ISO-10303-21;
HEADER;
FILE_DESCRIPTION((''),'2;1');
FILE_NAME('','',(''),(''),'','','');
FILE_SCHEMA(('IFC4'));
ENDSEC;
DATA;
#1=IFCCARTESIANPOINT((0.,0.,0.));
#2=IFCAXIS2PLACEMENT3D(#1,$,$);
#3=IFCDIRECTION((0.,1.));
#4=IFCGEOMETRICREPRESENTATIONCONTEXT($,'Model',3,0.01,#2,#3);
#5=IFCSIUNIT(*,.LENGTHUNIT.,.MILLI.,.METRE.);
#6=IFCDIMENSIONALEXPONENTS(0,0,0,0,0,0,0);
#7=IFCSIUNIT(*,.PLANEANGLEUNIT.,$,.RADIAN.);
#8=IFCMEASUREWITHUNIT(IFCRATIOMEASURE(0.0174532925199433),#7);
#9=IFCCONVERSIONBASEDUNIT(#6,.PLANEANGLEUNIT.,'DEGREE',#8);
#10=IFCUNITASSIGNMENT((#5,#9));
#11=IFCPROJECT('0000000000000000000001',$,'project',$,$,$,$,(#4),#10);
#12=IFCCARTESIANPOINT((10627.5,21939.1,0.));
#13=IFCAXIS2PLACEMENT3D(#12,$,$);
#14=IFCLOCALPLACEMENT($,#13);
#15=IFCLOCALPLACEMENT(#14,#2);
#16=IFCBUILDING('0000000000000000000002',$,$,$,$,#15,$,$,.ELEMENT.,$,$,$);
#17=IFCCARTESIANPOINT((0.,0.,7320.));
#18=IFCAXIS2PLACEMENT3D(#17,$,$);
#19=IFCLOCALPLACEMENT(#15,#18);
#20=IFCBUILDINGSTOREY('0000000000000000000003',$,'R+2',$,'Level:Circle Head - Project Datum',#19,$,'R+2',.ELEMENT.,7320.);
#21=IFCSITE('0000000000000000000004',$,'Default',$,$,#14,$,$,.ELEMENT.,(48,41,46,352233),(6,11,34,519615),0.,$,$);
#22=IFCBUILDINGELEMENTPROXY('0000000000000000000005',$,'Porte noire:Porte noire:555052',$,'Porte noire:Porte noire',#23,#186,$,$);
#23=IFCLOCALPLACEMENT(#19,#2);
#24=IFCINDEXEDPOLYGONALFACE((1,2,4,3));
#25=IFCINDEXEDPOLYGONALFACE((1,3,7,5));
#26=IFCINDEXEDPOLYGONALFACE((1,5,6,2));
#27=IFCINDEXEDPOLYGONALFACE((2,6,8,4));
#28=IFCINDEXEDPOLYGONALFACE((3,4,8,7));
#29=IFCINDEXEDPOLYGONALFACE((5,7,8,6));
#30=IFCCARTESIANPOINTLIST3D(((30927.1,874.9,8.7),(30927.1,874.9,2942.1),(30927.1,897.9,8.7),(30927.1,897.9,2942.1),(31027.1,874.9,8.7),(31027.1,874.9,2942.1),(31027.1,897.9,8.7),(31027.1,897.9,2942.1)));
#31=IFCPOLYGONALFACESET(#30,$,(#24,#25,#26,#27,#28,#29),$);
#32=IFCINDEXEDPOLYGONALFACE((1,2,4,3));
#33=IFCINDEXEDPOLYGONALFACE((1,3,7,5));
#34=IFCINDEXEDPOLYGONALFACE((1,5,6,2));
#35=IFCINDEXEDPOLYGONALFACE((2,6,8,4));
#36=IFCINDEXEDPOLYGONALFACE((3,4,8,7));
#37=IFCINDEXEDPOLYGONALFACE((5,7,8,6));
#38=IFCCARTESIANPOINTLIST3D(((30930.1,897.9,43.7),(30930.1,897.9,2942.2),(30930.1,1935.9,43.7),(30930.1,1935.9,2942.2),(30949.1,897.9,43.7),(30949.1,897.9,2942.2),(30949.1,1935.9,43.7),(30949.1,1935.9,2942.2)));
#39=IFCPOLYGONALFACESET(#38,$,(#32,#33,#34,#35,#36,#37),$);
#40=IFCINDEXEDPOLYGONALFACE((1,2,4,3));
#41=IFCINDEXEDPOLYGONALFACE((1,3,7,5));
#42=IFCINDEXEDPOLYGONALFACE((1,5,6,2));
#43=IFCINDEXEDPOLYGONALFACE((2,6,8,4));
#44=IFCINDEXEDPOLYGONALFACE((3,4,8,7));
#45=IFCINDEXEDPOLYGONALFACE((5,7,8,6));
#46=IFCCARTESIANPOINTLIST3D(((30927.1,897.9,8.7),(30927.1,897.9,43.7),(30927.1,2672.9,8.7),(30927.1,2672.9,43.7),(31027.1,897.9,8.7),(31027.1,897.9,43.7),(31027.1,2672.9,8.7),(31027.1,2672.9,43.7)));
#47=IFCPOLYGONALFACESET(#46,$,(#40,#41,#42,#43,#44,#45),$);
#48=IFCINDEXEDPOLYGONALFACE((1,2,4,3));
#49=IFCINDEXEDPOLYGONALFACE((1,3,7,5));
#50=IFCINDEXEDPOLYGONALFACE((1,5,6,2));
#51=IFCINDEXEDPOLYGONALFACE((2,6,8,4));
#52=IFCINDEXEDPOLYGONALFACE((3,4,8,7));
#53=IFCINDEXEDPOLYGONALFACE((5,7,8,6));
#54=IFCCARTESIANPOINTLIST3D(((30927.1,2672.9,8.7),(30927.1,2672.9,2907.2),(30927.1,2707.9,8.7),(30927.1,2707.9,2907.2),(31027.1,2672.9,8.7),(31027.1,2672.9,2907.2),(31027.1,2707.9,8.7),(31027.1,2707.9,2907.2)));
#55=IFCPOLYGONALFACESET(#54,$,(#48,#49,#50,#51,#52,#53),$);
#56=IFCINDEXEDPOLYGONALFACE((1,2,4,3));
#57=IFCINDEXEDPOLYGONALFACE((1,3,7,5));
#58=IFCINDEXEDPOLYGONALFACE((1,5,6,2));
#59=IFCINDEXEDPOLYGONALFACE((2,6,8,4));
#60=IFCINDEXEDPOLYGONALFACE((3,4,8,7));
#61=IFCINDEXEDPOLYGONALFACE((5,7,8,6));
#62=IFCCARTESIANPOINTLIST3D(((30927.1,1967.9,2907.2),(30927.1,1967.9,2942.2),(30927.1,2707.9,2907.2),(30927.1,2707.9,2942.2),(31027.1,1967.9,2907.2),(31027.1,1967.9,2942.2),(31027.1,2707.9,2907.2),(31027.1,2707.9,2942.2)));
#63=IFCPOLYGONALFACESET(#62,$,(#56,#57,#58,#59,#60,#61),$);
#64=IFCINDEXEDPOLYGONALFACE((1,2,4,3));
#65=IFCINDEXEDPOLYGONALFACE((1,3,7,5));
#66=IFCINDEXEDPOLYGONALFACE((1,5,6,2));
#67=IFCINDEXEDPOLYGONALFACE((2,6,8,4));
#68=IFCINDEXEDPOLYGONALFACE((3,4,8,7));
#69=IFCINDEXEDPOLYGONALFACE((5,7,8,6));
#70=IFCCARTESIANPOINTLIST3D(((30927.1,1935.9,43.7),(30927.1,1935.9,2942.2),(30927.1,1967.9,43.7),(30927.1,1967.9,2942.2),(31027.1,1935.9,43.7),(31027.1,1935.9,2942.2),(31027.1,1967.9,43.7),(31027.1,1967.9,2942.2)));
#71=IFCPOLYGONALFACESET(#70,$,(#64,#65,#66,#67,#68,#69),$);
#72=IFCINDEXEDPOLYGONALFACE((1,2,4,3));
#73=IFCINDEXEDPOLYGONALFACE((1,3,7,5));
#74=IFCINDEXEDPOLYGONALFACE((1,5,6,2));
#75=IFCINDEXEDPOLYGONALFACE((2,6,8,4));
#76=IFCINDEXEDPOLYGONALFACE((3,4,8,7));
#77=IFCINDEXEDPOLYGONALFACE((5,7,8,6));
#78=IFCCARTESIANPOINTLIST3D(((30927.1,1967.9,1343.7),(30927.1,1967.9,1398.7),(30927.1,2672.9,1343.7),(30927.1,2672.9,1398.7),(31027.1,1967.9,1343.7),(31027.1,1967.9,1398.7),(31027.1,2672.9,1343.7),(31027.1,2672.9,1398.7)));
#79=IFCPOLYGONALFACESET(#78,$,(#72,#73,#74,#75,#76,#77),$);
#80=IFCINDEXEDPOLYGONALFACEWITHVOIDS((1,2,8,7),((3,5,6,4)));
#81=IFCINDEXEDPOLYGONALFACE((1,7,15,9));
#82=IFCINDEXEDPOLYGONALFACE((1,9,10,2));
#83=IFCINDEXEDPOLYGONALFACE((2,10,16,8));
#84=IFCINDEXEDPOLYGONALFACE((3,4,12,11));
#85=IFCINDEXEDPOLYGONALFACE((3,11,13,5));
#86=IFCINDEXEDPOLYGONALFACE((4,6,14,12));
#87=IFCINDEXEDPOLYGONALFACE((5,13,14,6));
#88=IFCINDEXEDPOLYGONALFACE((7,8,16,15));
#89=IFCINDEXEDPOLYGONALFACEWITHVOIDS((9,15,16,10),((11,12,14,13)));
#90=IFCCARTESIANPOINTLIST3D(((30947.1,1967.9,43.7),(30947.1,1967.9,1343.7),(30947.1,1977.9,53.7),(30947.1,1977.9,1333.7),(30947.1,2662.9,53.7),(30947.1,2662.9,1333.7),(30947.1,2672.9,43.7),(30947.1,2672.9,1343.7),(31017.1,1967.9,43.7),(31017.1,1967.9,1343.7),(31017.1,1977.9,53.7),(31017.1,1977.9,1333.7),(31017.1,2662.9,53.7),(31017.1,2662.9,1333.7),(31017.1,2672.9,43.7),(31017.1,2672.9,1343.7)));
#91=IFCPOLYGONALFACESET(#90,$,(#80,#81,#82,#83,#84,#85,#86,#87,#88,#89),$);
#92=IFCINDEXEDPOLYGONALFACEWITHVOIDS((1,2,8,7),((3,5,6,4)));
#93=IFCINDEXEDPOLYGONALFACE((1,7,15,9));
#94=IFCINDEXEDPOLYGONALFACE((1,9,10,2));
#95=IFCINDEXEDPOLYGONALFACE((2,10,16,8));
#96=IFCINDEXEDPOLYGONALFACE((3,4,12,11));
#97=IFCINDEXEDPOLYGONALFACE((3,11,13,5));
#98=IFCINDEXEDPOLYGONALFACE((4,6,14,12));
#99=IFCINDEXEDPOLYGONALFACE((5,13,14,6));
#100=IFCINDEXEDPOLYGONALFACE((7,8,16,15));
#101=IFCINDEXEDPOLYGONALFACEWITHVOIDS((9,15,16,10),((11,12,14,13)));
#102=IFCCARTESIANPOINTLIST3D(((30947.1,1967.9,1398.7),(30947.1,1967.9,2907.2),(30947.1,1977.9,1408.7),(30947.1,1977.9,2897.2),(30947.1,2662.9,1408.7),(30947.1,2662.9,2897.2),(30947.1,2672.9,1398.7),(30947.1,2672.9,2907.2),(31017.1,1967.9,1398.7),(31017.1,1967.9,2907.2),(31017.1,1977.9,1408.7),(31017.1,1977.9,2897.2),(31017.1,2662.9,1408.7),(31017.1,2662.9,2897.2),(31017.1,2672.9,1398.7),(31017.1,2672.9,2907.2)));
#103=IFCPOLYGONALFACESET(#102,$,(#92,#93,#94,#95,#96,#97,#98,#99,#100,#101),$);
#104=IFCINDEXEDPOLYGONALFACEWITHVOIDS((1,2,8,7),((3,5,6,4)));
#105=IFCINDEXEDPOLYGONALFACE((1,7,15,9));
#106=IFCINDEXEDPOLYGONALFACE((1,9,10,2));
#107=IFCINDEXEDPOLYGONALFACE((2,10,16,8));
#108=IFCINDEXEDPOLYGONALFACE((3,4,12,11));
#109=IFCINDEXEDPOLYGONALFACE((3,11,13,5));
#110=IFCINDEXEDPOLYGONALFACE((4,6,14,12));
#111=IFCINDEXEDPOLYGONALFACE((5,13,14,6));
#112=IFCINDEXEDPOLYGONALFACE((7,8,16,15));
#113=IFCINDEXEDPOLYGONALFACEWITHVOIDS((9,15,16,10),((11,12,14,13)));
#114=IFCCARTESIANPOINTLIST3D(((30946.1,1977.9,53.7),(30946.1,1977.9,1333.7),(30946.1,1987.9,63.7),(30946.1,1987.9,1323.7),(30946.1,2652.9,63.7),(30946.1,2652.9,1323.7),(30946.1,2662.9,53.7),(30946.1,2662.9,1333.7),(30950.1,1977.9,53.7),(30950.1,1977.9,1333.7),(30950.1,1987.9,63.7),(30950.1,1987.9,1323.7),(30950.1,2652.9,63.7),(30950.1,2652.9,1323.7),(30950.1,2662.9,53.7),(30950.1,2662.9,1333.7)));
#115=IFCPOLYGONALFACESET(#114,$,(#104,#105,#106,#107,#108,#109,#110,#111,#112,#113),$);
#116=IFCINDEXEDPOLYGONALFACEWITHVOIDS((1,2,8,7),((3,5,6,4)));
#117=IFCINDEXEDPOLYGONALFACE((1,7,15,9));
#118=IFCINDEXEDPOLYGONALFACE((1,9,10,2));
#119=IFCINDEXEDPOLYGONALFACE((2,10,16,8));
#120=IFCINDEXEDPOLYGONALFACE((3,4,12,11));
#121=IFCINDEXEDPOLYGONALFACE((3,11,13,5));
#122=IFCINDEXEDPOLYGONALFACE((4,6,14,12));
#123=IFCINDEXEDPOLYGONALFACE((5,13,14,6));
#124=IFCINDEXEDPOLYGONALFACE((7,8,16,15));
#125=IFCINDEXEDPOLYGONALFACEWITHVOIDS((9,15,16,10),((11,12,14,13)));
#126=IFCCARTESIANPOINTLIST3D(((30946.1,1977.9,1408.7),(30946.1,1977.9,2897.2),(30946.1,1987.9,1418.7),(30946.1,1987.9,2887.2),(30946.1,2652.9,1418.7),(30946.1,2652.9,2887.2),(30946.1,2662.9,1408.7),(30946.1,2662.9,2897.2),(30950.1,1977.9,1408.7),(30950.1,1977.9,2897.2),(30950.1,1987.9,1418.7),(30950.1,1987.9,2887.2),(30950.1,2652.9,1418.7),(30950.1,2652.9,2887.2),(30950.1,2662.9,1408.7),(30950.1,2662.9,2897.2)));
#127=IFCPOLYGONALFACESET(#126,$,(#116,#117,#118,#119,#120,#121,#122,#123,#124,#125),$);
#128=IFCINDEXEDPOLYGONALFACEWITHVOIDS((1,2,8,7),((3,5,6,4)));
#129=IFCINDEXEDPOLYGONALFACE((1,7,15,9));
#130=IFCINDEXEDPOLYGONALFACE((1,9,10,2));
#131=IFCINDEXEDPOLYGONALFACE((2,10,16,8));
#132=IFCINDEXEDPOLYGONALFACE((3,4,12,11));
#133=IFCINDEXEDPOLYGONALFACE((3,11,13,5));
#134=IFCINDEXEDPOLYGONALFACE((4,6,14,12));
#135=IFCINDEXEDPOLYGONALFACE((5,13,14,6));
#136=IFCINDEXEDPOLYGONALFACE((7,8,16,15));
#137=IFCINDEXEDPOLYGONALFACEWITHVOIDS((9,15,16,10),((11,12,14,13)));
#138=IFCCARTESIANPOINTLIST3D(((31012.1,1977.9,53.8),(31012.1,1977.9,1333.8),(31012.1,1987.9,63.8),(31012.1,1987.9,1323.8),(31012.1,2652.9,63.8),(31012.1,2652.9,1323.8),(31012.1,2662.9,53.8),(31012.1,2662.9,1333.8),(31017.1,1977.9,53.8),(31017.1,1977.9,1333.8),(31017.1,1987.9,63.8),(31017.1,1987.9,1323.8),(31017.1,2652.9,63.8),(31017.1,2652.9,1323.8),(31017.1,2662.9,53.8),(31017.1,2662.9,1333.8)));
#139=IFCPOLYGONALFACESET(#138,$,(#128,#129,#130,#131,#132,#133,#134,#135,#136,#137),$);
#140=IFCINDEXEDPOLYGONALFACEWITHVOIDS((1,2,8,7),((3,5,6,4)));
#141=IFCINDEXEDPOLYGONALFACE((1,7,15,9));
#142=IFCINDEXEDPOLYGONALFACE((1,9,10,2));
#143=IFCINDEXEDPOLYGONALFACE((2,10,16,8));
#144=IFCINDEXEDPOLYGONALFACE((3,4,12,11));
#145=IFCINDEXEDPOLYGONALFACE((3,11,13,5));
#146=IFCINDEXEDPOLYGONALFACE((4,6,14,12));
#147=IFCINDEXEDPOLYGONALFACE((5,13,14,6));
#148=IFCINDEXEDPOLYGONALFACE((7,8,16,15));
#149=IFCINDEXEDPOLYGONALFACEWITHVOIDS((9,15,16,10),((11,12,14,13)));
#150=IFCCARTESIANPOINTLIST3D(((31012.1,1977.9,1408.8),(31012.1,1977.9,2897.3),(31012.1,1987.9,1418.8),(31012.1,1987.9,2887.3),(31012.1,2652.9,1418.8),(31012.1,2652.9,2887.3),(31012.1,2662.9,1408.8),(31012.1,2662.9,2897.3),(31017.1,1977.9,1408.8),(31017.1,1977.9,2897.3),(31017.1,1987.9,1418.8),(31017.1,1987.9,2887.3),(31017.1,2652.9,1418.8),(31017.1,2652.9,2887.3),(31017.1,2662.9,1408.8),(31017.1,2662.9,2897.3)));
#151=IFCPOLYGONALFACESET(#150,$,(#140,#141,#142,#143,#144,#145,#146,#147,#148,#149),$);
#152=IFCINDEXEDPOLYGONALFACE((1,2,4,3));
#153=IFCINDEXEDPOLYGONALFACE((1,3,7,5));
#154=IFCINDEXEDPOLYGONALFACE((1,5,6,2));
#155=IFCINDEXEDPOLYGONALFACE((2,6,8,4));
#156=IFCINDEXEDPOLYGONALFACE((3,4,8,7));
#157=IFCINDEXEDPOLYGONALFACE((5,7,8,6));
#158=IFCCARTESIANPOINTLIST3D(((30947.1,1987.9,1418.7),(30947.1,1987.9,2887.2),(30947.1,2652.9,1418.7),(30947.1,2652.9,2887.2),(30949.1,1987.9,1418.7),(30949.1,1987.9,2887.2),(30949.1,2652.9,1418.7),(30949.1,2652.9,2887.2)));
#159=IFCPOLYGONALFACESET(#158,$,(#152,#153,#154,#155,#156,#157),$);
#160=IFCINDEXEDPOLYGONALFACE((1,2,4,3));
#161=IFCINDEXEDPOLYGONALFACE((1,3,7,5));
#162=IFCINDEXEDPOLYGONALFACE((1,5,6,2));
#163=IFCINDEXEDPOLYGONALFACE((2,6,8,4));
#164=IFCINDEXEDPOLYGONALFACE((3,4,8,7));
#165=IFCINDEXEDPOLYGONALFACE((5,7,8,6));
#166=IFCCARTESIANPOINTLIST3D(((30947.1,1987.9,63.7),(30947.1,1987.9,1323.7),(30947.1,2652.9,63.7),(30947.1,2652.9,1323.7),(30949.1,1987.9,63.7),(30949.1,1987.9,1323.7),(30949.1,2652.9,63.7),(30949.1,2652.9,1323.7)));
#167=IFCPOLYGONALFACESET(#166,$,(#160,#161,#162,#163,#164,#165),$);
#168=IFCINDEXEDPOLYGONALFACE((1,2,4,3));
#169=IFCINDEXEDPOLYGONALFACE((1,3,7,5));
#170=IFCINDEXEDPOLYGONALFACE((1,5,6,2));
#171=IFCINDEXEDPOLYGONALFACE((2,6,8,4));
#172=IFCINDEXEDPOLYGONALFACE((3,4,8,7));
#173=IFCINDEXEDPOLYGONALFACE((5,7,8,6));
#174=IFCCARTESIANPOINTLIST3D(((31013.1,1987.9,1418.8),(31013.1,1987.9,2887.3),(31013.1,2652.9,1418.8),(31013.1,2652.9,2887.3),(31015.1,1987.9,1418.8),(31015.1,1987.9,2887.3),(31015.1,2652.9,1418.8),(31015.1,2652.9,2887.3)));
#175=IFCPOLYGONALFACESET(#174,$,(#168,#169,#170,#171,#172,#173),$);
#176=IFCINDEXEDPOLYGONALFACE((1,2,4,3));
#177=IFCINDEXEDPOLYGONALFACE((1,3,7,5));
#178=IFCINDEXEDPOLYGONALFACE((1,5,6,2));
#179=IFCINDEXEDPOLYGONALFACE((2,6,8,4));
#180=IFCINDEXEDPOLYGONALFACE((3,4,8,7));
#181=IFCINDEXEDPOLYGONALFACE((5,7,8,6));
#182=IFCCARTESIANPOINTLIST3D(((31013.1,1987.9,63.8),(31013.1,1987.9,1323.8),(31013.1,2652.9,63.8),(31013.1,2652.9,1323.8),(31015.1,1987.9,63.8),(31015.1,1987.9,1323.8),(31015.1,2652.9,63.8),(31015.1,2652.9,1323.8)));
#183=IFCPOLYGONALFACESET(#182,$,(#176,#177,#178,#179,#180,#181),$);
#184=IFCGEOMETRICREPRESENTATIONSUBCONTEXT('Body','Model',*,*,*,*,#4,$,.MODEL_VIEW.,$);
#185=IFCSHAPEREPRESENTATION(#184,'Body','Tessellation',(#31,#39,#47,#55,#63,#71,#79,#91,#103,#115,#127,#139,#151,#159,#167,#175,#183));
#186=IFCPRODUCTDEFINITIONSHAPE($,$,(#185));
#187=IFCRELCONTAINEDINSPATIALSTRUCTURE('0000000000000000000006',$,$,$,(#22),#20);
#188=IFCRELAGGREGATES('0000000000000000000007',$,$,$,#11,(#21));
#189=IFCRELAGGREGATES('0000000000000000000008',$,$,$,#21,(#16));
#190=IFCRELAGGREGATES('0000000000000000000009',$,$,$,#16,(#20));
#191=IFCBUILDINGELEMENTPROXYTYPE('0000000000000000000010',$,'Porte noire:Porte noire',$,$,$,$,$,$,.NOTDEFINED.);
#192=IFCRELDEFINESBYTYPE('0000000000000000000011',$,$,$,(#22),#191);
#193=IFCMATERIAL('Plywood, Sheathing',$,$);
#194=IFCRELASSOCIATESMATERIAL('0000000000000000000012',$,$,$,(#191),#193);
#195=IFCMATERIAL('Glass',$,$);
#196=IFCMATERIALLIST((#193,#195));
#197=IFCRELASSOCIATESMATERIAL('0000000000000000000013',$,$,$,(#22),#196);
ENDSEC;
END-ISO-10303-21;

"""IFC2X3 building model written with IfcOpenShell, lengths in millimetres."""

from ifc_helpers import new_model, entity, si_unit, converted_unit, direction, frame, frame_2d, origin, origin_2d_with_axis, place, context, subcontext, project, spatial, polyline, rectangle, outline, extrude, source, transform, mapped, material, material_list, type_object, type_shapes, element, save


model = new_model("IFC2X3")

# Units and contexts
model_context = context("Model", 3, precision=0.01, world=origin(), true_north=direction((0.0, 1.0)))
body_context = subcontext(model_context, "Body", "Model", "MODEL_VIEW")
ifc_project = project(units=[si_unit("LENGTHUNIT", "METRE", prefix="MILLI"), converted_unit("PLANEANGLEUNIT", "DEGREE", entity("IfcRatioMeasure", 0.0174532925199433), si_unit("PLANEANGLEUNIT", "RADIAN"), dimensions=[0, 0, 0, 0, 0, 0, 0])], contexts=[model_context])

# Site, building, storey
site_placement = place(None, frame((10627.5, 21939.1, 0.0)))
site = spatial("IfcSite", under=ifc_project, at=site_placement, Name="Default", CompositionType="ELEMENT", RefLatitude=(48, 41, 46, 352233), RefLongitude=(6, 11, 34, 519615), RefElevation=0.0)
building_placement = place(site_placement, origin())
building = spatial("IfcBuilding", under=site, at=building_placement, CompositionType="ELEMENT")
storey_placement = place(building_placement, frame((0.0, 0.0, 7320.0)))
storey = spatial("IfcBuildingStorey", under=building, at=storey_placement, Name="R+2", ObjectType="Level:Circle Head - Project Datum", LongName="R+2", CompositionType="ELEMENT", Elevation=7320.0)

# Building element proxy
ifc_material_1 = material(Name="Glass")
ifc_material_2 = material(Name="Plywood, Sheathing")
ifc_material_list_1 = material_list([ifc_material_2, ifc_material_1])
building_element_proxy_type_1 = type_object("IfcBuildingElementProxyType", Name="Porte noire:Porte noire", PredefinedType="NOTDEFINED", material=ifc_material_2)
shared_shape_1 = source(origin(), body_context, "Body", "SweptSolid", [
    extrude(rectangle(XDim=23.0, YDim=100.0, at=frame_2d((0.0, 0.0), x_axis=(1.0, 0.0))), frame((-950.9, 50.0, 8.7), z_axis=(0.0, 0.0, 1.0), x_axis=(-1.0, 0.0, 0.0)), (0.0, 0.0, 1.0), 2933.3),
    extrude(rectangle(XDim=1038.0, YDim=19.0, at=frame_2d((0.0, 0.0), x_axis=(1.0, 0.0))), frame((-420.4, 87.5, 43.7), z_axis=(0.0, 0.0, 1.0), x_axis=(-1.0, 0.0, 0.0)), (0.0, 0.0, 1.0), 2898.5),
    extrude(rectangle(XDim=1775.0, YDim=100.0, at=origin_2d_with_axis()), frame((-51.9, 50.0, 8.7), z_axis=(0.0, 0.0, 1.0), x_axis=(-1.0, 0.0, 0.0)), (0.0, 0.0, 1.0), 35.0),
    extrude(rectangle(XDim=35.0, YDim=100.0, at=origin_2d_with_axis()), frame((853.1, 50.0, 8.7), z_axis=(0.0, 0.0, 1.0), x_axis=(-1.0, 0.0, 0.0)), (0.0, 0.0, 1.0), 2898.5),
    extrude(rectangle(XDim=740.0, YDim=100.0, at=origin_2d_with_axis()), frame((500.6, 50.0, 2907.2), z_axis=(0.0, 0.0, 1.0), x_axis=(-1.0, 0.0, 0.0)), (0.0, 0.0, 1.0), 35.0),
    extrude(rectangle(XDim=32.0, YDim=100.0, at=origin_2d_with_axis()), frame((114.6, 50.0, 43.7), z_axis=(0.0, 0.0, 1.0), x_axis=(-1.0, 0.0, 0.0)), (0.0, 0.0, 1.0), 2898.5),
    extrude(rectangle(XDim=705.0, YDim=100.0, at=origin_2d_with_axis()), frame((483.1, 50.0, 1343.7), z_axis=(0.0, 0.0, 1.0), x_axis=(-1.0, 0.0, 0.0)), (0.0, 0.0, 1.0), 55.0),
    extrude(outline(polyline([(-352.5, -650.0), (352.5, -650.0), (352.5, 650.0), (-352.5, 650.0), (-352.5, -650.0)]), holes=[polyline([(342.5, 640.0), (342.5, -640.0), (-342.5, -640.0), (-342.5, 640.0), (342.5, 640.0)])]), frame((483.1, 10.0, 693.7), z_axis=(0.0, 1.0, 0.0), x_axis=(1.0, 0.0, 0.0)), (0.0, 0.0, 1.0), 70.0),
    extrude(outline(polyline([(-754.2, -352.5), (754.2, -352.5), (754.2, 352.5), (-754.2, 352.5), (-754.2, -352.5)]), holes=[polyline([(744.2, 342.5), (744.2, -342.5), (-744.2, -342.5), (-744.2, 342.5), (744.2, 342.5)])]), frame((483.1, 10.0, 2153.0), z_axis=(0.0, 1.0, 0.0), x_axis=(0.0, 0.0, 1.0)), (0.0, 0.0, 1.0), 70.0),
    extrude(outline(polyline([(-640.0, -342.5), (640.0, -342.5), (640.0, 342.5), (-640.0, 342.5), (-640.0, -342.5)]), holes=[polyline([(630.0, 332.5), (630.0, -332.5), (-630.0, -332.5), (-630.0, 332.5), (630.0, 332.5)])]), frame((483.1, 77.0, 693.7), z_axis=(0.0, 1.0, 0.0), x_axis=(0.0, 0.0, 1.0)), (0.0, 0.0, 1.0), 4.0),
    extrude(outline(polyline([(-744.2, -342.5), (744.2, -342.5), (744.2, 342.5), (-744.2, 342.5), (-744.2, -342.5)]), holes=[polyline([(734.2, 332.5), (734.2, -332.5), (-734.2, -332.5), (-734.2, 332.5), (734.2, 332.5)])]), frame((483.1, 77.0, 2153.0), z_axis=(0.0, 1.0, 0.0), x_axis=(0.0, 0.0, 1.0)), (0.0, 0.0, 1.0), 4.0),
    extrude(outline(polyline([(-640.0, -342.5), (640.0, -342.5), (640.0, 342.5), (-640.0, 342.5), (-640.0, -342.5)]), holes=[polyline([(630.0, 332.5), (630.0, -332.5), (-630.0, -332.5), (-630.0, 332.5), (630.0, 332.5)])]), frame((483.1, 10.0, 693.8), z_axis=(0.0, 1.0, 0.0), x_axis=(0.0, 0.0, 1.0)), (0.0, 0.0, 1.0), 5.0),
    extrude(outline(polyline([(-744.2, -342.5), (744.2, -342.5), (744.2, 342.5), (-744.2, 342.5), (-744.2, -342.5)]), holes=[polyline([(734.2, 332.5), (734.2, -332.5), (-734.2, -332.5), (-734.2, 332.5), (734.2, 332.5)])]), frame((483.1, 10.0, 2153.0), z_axis=(0.0, 1.0, 0.0), x_axis=(0.0, 0.0, 1.0)), (0.0, 0.0, 1.0), 5.0),
    extrude(rectangle(XDim=665.0, YDim=2.0, at=frame_2d((0.0, 0.0), x_axis=(1.0, 0.0))), frame((483.1, 79.0, 1418.7), z_axis=(0.0, 0.0, 1.0), x_axis=(-1.0, 0.0, 0.0)), (0.0, 0.0, 1.0), 1468.5),
    extrude(rectangle(XDim=665.0, YDim=2.0, at=frame_2d((0.0, 0.0), x_axis=(1.0, 0.0))), frame((483.1, 79.0, 63.7), z_axis=(0.0, 0.0, 1.0), x_axis=(-1.0, 0.0, 0.0)), (0.0, 0.0, 1.0), 1260.0),
    extrude(rectangle(XDim=665.0, YDim=2.0, at=frame_2d((0.0, 0.0), x_axis=(1.0, 0.0))), frame((483.1, 13.0, 1418.8), z_axis=(0.0, 0.0, 1.0), x_axis=(-1.0, 0.0, 0.0)), (0.0, 0.0, 1.0), 1468.5),
    extrude(rectangle(XDim=665.0, YDim=2.0, at=frame_2d((0.0, 0.0), x_axis=(1.0, 0.0))), frame((483.1, 13.0, 63.8), z_axis=(0.0, 0.0, 1.0), x_axis=(-1.0, 0.0, 0.0)), (0.0, 0.0, 1.0), 1260.0),
])
type_shapes(building_element_proxy_type_1, [shared_shape_1])
proxy_1_placement = place(storey_placement, frame((31027.1, 1837.3, 0.0), z_axis=(0.0, 0.0, 1.0), x_axis=(0.0, 1.0, 0.0)))
element("IfcBuildingElementProxy", 1, at=proxy_1_placement, inside=storey, type_object=building_element_proxy_type_1, material=ifc_material_list_1, Name="Porte noire:Porte noire:555052", ObjectType="Porte noire:Porte noire", context=body_context, shape_type="MappedRepresentation", body=[
    mapped(shared_shape_1, transform((0.0, 0.0, 0.0), scale=1.0)),
])

save(model, "model.ifc")
